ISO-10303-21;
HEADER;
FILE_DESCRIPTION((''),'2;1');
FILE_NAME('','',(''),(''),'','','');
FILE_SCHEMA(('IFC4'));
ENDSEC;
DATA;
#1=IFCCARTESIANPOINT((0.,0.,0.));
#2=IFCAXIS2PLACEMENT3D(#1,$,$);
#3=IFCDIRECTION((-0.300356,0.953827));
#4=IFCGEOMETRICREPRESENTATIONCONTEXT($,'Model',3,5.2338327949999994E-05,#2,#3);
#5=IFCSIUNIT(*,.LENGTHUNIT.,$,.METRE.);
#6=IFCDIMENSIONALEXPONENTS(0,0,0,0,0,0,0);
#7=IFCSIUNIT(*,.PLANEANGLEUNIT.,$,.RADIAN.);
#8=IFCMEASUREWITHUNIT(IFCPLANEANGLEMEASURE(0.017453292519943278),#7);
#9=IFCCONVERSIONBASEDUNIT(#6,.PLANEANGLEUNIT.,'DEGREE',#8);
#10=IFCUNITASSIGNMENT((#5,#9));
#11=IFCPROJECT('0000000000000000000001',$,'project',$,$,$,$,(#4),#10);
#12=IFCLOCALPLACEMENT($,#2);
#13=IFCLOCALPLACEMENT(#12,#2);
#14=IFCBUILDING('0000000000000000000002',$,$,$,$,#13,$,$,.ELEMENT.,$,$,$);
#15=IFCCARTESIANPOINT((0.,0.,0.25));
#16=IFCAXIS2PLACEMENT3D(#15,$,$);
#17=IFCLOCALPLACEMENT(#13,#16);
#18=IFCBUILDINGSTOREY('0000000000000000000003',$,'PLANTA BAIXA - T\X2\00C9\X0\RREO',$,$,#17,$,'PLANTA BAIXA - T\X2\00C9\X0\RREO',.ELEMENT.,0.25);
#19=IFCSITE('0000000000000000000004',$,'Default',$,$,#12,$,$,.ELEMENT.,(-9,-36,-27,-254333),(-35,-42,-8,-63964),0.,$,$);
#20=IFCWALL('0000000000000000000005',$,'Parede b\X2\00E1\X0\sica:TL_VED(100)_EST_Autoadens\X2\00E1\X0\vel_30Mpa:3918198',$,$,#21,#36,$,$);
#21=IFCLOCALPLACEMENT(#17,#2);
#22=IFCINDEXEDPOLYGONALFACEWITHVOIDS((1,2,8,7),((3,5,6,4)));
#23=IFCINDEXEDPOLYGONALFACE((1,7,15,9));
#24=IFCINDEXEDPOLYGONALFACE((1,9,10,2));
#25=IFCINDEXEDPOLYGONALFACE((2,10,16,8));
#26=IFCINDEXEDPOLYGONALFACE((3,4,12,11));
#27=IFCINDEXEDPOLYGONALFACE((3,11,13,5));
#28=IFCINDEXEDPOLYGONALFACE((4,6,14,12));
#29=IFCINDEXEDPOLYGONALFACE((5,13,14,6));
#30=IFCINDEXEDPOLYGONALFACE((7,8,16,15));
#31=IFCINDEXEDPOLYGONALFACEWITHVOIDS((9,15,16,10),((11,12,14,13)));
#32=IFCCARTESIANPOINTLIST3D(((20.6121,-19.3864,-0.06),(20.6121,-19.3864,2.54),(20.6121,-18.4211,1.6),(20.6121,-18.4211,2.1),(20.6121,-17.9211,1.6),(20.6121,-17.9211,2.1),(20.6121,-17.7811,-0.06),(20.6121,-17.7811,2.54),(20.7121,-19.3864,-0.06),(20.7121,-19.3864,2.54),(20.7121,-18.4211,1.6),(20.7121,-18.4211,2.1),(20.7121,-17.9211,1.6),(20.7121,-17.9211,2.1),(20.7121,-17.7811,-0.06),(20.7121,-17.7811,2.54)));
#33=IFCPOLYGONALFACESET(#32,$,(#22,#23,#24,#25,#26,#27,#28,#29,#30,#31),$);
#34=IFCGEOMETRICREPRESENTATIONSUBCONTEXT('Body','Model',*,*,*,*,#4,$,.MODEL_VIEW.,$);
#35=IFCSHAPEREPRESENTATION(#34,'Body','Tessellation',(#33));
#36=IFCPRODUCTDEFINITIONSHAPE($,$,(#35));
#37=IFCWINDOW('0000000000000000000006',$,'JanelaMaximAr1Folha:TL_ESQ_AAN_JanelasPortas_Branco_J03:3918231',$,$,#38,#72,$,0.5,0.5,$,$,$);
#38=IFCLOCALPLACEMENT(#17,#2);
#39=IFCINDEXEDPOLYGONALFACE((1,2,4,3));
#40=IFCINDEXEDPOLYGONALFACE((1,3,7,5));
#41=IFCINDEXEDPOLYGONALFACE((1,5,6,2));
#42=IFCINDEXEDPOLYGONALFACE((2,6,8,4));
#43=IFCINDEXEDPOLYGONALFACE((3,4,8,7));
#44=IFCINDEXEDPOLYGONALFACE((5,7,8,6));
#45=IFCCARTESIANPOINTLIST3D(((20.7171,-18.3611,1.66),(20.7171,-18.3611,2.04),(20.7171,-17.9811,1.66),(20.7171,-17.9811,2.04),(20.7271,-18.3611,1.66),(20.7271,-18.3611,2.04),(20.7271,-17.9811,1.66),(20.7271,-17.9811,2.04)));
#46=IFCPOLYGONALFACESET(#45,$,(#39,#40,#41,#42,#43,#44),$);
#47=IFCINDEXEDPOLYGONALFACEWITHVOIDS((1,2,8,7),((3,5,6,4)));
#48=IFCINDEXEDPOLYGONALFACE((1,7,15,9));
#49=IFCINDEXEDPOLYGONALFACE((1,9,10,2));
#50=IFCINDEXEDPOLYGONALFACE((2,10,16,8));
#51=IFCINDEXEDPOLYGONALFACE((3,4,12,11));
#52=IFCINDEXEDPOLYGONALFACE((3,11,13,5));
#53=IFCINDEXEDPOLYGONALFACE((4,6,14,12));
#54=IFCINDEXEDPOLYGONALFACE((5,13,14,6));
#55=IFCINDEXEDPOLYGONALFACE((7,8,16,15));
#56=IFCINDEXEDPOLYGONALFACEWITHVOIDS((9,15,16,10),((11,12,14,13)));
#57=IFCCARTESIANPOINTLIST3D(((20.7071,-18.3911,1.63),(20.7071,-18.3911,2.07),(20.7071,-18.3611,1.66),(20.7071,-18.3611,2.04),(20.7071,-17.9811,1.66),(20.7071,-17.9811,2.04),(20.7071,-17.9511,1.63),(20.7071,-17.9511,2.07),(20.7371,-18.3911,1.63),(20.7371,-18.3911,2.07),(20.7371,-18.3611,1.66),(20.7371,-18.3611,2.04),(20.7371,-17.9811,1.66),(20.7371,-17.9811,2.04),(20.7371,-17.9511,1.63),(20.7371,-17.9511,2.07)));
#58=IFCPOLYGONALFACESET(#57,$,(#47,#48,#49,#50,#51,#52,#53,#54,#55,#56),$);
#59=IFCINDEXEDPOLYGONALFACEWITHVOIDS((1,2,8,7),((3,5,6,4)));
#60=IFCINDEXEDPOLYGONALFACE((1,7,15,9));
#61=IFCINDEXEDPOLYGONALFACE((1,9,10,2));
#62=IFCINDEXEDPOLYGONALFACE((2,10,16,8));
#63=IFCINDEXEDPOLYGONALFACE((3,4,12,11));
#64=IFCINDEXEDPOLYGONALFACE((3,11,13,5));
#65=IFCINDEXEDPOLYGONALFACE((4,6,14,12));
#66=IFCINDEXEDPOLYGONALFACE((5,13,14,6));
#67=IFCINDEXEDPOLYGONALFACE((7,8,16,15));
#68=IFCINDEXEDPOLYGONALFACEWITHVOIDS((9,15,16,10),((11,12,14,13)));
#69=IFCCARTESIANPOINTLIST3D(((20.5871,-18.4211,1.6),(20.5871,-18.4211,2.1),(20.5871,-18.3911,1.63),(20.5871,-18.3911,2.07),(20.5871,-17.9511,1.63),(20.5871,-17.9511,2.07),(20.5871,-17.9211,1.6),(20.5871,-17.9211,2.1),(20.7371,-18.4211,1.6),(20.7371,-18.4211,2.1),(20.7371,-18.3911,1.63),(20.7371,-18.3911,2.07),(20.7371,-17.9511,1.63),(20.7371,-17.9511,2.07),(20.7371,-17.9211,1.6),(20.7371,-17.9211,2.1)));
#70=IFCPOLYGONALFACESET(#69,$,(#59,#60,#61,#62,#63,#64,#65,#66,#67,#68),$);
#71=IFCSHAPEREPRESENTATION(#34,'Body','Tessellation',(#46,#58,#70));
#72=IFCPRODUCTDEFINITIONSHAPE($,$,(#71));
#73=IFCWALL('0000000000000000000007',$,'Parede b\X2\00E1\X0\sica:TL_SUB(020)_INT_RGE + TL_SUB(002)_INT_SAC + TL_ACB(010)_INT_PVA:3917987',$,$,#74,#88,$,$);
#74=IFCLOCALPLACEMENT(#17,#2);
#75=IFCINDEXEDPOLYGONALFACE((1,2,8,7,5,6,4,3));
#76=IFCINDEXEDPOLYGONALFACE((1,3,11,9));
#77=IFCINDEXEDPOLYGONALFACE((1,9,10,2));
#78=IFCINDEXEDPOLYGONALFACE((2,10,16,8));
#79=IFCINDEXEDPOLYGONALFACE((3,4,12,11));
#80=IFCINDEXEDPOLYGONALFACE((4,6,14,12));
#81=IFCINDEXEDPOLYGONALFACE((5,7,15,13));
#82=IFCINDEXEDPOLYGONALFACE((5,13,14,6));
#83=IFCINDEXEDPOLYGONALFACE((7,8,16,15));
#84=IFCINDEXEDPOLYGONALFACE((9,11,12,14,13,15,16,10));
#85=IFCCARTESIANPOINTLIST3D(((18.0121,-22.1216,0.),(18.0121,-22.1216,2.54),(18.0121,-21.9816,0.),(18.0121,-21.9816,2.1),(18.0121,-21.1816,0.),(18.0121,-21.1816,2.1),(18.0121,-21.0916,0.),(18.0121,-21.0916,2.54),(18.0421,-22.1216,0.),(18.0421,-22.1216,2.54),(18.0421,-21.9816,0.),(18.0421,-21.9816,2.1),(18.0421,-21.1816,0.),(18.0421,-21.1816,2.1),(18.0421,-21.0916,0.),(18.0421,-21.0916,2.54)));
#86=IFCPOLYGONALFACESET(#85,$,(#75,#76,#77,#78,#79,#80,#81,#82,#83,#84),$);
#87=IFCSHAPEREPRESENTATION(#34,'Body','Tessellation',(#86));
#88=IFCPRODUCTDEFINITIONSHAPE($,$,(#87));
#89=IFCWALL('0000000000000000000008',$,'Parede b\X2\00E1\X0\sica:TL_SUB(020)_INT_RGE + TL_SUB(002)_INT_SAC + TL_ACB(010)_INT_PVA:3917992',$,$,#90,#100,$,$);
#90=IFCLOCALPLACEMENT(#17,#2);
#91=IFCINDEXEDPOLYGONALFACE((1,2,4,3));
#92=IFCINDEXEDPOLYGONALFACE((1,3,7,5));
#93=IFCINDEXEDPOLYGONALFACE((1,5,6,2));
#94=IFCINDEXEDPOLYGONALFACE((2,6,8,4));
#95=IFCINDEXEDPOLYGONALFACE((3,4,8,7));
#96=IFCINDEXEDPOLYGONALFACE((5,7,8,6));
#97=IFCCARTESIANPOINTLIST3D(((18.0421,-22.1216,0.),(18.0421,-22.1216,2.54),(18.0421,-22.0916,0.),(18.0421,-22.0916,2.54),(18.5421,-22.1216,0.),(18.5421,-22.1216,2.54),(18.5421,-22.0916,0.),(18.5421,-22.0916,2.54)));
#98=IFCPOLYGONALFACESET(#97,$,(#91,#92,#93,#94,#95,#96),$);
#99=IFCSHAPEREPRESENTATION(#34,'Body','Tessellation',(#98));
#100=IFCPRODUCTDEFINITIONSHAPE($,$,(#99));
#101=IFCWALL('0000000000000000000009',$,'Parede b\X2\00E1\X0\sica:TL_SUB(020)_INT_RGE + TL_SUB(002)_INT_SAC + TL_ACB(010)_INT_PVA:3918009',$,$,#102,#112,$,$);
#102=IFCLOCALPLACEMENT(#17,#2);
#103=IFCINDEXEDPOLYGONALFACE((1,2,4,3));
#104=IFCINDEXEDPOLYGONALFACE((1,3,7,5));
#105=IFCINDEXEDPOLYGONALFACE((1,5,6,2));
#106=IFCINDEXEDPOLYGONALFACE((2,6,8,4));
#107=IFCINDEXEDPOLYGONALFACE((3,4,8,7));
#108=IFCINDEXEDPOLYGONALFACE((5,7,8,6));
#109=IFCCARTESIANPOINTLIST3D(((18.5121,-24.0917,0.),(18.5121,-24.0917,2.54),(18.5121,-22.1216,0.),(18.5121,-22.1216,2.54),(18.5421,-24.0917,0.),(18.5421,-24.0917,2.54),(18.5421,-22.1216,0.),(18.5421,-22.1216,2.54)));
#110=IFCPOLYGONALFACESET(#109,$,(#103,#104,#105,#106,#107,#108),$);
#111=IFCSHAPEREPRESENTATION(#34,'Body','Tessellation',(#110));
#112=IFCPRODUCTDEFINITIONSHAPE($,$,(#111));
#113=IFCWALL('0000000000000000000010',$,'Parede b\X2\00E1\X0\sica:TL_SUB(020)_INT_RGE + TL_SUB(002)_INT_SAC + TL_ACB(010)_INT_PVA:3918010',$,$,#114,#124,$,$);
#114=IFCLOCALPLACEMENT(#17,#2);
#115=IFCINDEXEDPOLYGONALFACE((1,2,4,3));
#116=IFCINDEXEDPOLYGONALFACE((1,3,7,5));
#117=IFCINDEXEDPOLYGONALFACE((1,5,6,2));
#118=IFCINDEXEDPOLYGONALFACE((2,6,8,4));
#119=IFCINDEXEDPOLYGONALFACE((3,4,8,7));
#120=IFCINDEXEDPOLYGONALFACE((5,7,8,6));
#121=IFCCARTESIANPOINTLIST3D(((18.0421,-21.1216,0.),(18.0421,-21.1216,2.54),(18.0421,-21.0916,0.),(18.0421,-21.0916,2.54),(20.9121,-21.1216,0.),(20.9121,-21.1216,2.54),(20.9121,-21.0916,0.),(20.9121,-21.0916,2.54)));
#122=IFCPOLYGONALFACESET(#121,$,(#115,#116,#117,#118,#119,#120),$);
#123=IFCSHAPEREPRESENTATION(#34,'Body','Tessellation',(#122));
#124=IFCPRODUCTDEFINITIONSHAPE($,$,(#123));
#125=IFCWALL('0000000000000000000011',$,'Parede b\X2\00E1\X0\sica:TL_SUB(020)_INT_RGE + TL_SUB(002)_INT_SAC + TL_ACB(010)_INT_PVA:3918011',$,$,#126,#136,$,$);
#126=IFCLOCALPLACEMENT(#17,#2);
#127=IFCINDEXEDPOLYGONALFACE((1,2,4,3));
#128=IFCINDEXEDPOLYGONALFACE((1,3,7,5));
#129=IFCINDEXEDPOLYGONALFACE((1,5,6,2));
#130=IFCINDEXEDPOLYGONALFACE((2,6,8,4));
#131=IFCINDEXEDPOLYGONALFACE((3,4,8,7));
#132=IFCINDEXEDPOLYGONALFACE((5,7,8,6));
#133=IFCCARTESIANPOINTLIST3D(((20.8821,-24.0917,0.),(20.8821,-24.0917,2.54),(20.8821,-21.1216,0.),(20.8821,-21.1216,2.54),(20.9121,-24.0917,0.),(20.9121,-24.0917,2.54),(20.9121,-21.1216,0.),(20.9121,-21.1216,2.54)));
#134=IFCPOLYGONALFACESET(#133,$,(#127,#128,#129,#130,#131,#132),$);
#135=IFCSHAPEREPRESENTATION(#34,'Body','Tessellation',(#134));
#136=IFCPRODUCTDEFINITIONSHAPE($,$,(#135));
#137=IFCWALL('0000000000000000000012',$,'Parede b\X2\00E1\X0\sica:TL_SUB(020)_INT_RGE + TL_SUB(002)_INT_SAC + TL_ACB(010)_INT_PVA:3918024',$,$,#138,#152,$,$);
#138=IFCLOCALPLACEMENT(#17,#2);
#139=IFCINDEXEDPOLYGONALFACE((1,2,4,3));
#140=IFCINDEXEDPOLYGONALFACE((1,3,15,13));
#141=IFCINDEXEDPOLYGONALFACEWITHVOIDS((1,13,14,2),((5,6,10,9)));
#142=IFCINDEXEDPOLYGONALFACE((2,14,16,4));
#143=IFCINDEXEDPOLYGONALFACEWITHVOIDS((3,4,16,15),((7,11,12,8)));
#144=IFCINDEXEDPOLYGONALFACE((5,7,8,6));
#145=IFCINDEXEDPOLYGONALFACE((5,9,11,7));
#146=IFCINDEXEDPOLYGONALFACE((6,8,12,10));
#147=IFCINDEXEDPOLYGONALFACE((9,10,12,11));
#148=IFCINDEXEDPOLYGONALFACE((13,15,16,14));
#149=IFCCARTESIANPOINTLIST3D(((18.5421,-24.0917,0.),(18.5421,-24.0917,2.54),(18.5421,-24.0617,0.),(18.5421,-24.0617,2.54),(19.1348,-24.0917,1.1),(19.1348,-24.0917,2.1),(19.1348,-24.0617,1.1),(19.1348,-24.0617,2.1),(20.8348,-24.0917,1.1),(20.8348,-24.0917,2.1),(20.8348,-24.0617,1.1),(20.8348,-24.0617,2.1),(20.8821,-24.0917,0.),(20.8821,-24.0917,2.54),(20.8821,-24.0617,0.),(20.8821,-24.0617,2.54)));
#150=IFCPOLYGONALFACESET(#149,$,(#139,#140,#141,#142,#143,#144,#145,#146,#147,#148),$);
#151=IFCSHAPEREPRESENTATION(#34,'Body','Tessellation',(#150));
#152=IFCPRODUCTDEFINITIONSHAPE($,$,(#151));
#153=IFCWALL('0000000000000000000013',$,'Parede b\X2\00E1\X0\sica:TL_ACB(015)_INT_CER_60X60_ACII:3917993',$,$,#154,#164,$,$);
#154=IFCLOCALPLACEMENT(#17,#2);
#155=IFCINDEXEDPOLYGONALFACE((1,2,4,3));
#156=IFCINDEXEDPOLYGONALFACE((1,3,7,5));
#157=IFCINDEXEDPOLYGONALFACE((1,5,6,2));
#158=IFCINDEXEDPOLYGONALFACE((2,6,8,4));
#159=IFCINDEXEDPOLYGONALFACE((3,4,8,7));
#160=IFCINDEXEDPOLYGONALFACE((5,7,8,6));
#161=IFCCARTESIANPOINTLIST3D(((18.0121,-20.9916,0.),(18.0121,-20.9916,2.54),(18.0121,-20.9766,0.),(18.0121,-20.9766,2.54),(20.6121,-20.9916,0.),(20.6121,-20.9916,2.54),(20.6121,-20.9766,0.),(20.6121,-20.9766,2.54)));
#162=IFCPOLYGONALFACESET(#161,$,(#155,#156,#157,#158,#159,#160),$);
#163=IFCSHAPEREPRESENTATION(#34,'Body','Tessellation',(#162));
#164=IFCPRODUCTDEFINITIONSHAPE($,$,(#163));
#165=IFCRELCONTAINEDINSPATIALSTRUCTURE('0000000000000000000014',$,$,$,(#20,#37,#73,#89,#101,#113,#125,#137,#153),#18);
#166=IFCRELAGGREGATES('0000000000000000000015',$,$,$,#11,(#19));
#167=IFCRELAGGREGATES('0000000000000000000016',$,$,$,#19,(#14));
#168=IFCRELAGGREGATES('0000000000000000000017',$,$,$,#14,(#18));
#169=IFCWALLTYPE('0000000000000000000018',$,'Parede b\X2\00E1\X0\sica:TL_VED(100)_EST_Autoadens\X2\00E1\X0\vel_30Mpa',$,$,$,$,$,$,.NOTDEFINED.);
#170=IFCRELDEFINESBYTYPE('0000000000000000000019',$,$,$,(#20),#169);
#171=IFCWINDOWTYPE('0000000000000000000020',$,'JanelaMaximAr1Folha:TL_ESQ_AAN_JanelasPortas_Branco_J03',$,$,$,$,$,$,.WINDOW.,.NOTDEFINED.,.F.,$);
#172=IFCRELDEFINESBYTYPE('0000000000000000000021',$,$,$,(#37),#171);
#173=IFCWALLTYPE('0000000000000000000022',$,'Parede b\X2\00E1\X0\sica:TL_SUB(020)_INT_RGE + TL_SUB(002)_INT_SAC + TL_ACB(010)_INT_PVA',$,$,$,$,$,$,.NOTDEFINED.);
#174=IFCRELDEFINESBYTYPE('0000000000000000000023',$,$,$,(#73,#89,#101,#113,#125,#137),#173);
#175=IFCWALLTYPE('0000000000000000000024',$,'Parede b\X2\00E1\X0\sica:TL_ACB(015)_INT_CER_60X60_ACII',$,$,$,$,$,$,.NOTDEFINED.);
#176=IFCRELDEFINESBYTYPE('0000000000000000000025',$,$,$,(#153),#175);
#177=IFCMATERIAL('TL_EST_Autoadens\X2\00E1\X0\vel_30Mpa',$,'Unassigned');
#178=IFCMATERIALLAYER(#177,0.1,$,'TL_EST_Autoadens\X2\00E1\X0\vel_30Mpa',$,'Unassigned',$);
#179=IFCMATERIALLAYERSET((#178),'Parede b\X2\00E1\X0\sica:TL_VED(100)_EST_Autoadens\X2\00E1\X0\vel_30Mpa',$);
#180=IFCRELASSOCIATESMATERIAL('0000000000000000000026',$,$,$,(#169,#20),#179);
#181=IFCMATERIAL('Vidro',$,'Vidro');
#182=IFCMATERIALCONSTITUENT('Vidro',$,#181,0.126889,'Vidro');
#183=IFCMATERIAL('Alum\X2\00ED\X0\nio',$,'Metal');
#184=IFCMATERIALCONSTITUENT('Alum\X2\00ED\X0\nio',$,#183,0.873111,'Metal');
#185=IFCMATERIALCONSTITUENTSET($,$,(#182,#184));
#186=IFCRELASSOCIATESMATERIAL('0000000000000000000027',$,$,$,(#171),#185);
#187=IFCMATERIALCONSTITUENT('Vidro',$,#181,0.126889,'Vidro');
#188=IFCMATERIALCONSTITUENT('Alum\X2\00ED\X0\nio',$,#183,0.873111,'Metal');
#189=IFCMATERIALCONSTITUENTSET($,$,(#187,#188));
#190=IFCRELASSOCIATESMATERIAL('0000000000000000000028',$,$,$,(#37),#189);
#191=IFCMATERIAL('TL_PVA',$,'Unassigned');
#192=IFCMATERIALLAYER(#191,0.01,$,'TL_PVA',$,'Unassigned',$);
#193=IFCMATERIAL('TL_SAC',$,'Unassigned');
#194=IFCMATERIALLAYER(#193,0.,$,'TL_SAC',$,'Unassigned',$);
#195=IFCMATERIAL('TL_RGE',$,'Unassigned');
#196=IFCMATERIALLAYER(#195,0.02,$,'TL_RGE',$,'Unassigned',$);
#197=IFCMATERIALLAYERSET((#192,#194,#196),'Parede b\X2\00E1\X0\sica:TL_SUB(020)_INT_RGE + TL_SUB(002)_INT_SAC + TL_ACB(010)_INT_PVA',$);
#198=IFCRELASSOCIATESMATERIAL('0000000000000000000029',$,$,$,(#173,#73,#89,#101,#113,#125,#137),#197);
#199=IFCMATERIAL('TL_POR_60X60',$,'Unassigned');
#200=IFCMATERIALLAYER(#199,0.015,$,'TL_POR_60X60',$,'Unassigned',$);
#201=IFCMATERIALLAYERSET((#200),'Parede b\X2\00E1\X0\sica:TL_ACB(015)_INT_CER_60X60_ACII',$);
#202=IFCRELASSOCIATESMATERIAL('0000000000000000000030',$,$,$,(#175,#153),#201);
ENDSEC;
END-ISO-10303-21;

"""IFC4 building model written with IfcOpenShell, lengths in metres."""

from ifc_helpers import new_model, entity, si_unit, converted_unit, direction, frame, frame_2d, origin, place, context, subcontext, project, spatial, polyline, rectangle, outline, extrude, source, transform, mapped, material, layer, layer_set, layer_usage, constituent, constituent_set, type_object, type_shapes, element, fill, save


model = new_model("IFC4")

# Units and contexts
model_context = context("Model", 3, precision=5.2338327949999994e-05, world=origin(), true_north=direction((-0.300356, 0.953827)))
body_context = subcontext(model_context, "Body", "Model", "MODEL_VIEW")
ifc_project = project(units=[si_unit("LENGTHUNIT", "METRE"), converted_unit("PLANEANGLEUNIT", "DEGREE", entity("IfcPlaneAngleMeasure", 0.017453292519943278), si_unit("PLANEANGLEUNIT", "RADIAN"), dimensions=[0, 0, 0, 0, 0, 0, 0])], contexts=[model_context])

# Site, building, storey
site_placement = place(None, origin())
site = spatial("IfcSite", under=ifc_project, at=site_placement, Name="Default", CompositionType="ELEMENT", RefLatitude=(-9, -36, -27, -254333), RefLongitude=(-35, -42, -8, -63964), RefElevation=0.0)
building_placement = place(site_placement, origin())
building = spatial("IfcBuilding", under=site, at=building_placement, CompositionType="ELEMENT")
storey_placement = place(building_placement, frame((0.0, 0.0, 0.25)))
storey = spatial("IfcBuildingStorey", under=building, at=storey_placement, Name="PLANTA BAIXA - TÉRREO", LongName="PLANTA BAIXA - TÉRREO", CompositionType="ELEMENT", Elevation=0.25)

# Shared definitions
ifc_material_1 = material(Name="TL_EST_Autoadensável_30Mpa", Category="Unassigned")
ifc_layer_1 = layer(ifc_material_1, 0.1, Name="TL_EST_Autoadensável_30Mpa", Category="Unassigned")
ifc_layer_set_1 = layer_set([ifc_layer_1], Name="Parede básica:TL_VED(100)_EST_Autoadensável_30Mpa")
wall_type_1 = type_object("IfcWallType", Name="Parede básica:TL_VED(100)_EST_Autoadensável_30Mpa", PredefinedType="NOTDEFINED", material=ifc_layer_set_1)

# Wall, opening, window
ifc_material_2 = material(Name="Vidro", Category="Vidro")
ifc_material_3 = material(Name="Alumínio", Category="Metal")
ifc_layer_usage_1 = layer_usage(ifc_layer_set_1, "AXIS2", "POSITIVE", -0.05)
wall_1_placement = place(storey_placement, frame((20.6621, -19.3864, -0.06), z_axis=(0.0, 0.0, 1.0), x_axis=(0.0, 1.0, 0.0)))
wall_1 = element("IfcWall", 1, at=wall_1_placement, inside=storey, type_object=wall_type_1, material=ifc_layer_usage_1, Name="Parede básica:TL_VED(100)_EST_Autoadensável_30Mpa:3918198", context=body_context, shape_type="SweptSolid", body=[
    extrude(rectangle(XDim=1.6052, YDim=0.1, at=frame_2d((0.8026, 0.0), x_axis=(-1.0, 0.0))), origin(), (0.0, 0.0, 1.0), 2.6),
])
opening_1_placement = place(wall_1_placement, frame((0.9652, -0.05, 1.66)))
opening_1 = element("IfcOpeningElement", 2, at=opening_1_placement, cuts=wall_1, PredefinedType="OPENING", context=body_context, shape_type="SweptSolid", body=[
    extrude(rectangle(XDim=0.5, YDim=0.5, at=frame_2d((0.25, 0.25), x_axis=(1.0, 0.0))), frame((0.0, 0.0, 0.0), z_axis=(0.0, 1.0, 0.0), x_axis=(0.0, 0.0, 1.0)), (0.0, 0.0, 1.0), 0.1),
])
ifc_constituent_1 = constituent(ifc_material_2, Name="Vidro", Category="Vidro", fraction=0.126889)
ifc_constituent_2 = constituent(ifc_material_3, Name="Alumínio", Category="Metal", fraction=0.873111)
ifc_constituent_set_1 = constituent_set(constituents=[ifc_constituent_1, ifc_constituent_2])
ifc_constituent_3 = constituent(ifc_material_2, Name="Vidro", Category="Vidro", fraction=0.126889)
ifc_constituent_4 = constituent(ifc_material_3, Name="Alumínio", Category="Metal", fraction=0.873111)
ifc_constituent_set_2 = constituent_set(constituents=[ifc_constituent_3, ifc_constituent_4])
window_type_1 = type_object("IfcWindowType", Name="JanelaMaximAr1Folha:TL_ESQ_AAN_JanelasPortas_Branco_J03", ParameterTakesPrecedence=False, PartitioningType="NOTDEFINED", PredefinedType="WINDOW", material=ifc_constituent_set_2)
shared_shape_1 = source(origin(), body_context, "Body", "SweptSolid", [
    extrude(rectangle(XDim=0.38, YDim=0.01, at=frame_2d((0.0, 0.0), x_axis=(1.0, 0.0))), frame((0.25, -0.01, 0.06)), (0.0, 0.0, 1.0), 0.38),
    extrude(outline(polyline([(-0.22, -0.22), (0.22, -0.22), (0.22, 0.22), (-0.22, 0.22), (-0.22, -0.22)]), holes=[polyline([(0.19, 0.19), (0.19, -0.19), (-0.19, -0.19), (-0.19, 0.19), (0.19, 0.19)])]), frame((0.25, 0.005, 0.25), z_axis=(0.0, -1.0, 0.0), x_axis=(0.0, 0.0, -1.0)), (0.0, 0.0, 1.0), 0.03),
    extrude(outline(polyline([(-0.25, -0.25), (0.25, -0.25), (0.25, 0.25), (-0.25, 0.25), (-0.25, -0.25)]), holes=[polyline([(-0.22, -0.22), (-0.22, 0.22), (0.22, 0.22), (0.22, -0.22), (-0.22, -0.22)])]), frame((0.25, 0.125, 0.25), z_axis=(0.0, -1.0, 0.0), x_axis=(0.0, 0.0, -1.0)), (0.0, 0.0, 1.0), 0.15),
])
type_shapes(window_type_1, [shared_shape_1])
window_1_placement = place(opening_1_placement, origin())
window_1 = element("IfcWindow", 3, at=window_1_placement, inside=storey, type_object=window_type_1, material=ifc_constituent_set_1, Name="JanelaMaximAr1Folha:TL_ESQ_AAN_JanelasPortas_Branco_J03:3918231", OverallHeight=0.5, OverallWidth=0.5, context=body_context, shape_type="MappedRepresentation", body=[
    mapped(shared_shape_1, transform((0.0, 0.0, 0.0), scale=1.0)),
])
fill(opening_1, window_1)

# Wall, opening
ifc_material_4 = material(Name="TL_PVA", Category="Unassigned")
ifc_layer_2 = layer(ifc_material_4, 0.01, Name="TL_PVA", Category="Unassigned")
ifc_material_5 = material(Name="TL_SAC", Category="Unassigned")
ifc_layer_3 = layer(ifc_material_5, 0.0, Name="TL_SAC", Category="Unassigned")
ifc_material_6 = material(Name="TL_RGE", Category="Unassigned")
ifc_layer_4 = layer(ifc_material_6, 0.02, Name="TL_RGE", Category="Unassigned")
ifc_layer_set_2 = layer_set([ifc_layer_2, ifc_layer_3, ifc_layer_4], Name="Parede básica:TL_SUB(020)_INT_RGE + TL_SUB(002)_INT_SAC + TL_ACB(010)_INT_PVA")
ifc_layer_usage_2 = layer_usage(ifc_layer_set_2, "AXIS2", "POSITIVE", -0.015)
wall_type_2 = type_object("IfcWallType", Name="Parede básica:TL_SUB(020)_INT_RGE + TL_SUB(002)_INT_SAC + TL_ACB(010)_INT_PVA", PredefinedType="NOTDEFINED", material=ifc_layer_set_2)
wall_2_placement = place(storey_placement, frame((18.0271, -22.1216, 0.0), z_axis=(0.0, 0.0, 1.0), x_axis=(0.0, 1.0, 0.0)))
wall_2 = element("IfcWall", 4, at=wall_2_placement, inside=storey, type_object=wall_type_2, material=ifc_layer_usage_2, Name="Parede básica:TL_SUB(020)_INT_RGE + TL_SUB(002)_INT_SAC + TL_ACB(010)_INT_PVA:3917987", context=body_context, shape_type="SweptSolid", body=[
    extrude(rectangle(XDim=1.03, YDim=0.03, at=frame_2d((0.515, 0.0), x_axis=(-1.0, 0.0))), origin(), (0.0, 0.0, 1.0), 2.54),
])
opening_2_placement = place(wall_2_placement, frame((22.1216, 18.0271, 0.0)))
element("IfcOpeningElement", 5, at=opening_2_placement, cuts=wall_2, PredefinedType="OPENING", context=body_context, shape_type="SweptSolid", body=[
    extrude(rectangle(XDim=2.1, YDim=0.8, at=frame_2d((0.0, 0.0), x_axis=(0.0, 1.0))), frame((-21.5816, -19.4361, 1.05), z_axis=(0.0, 1.0, 0.0), x_axis=(-1.0, 0.0, 0.0)), (0.0, 0.0, 1.0), 3.048),
])

# Walls
ifc_layer_usage_3 = layer_usage(ifc_layer_set_2, "AXIS2", "POSITIVE", -0.015)
wall_3_placement = place(storey_placement, frame((18.5421, -22.1066, 0.0), z_axis=(0.0, 0.0, 1.0), x_axis=(-1.0, 0.0, 0.0)))
element("IfcWall", 6, at=wall_3_placement, inside=storey, type_object=wall_type_2, material=ifc_layer_usage_3, Name="Parede básica:TL_SUB(020)_INT_RGE + TL_SUB(002)_INT_SAC + TL_ACB(010)_INT_PVA:3917992", context=body_context, shape_type="SweptSolid", body=[
    extrude(rectangle(XDim=0.5, YDim=0.03, at=frame_2d((0.25, 0.0), x_axis=(-1.0, 0.0))), origin(), (0.0, 0.0, 1.0), 2.54),
])
ifc_layer_usage_4 = layer_usage(ifc_layer_set_2, "AXIS2", "NEGATIVE", 0.015)
wall_4_placement = place(storey_placement, frame((18.5271, -22.1216, 0.0), z_axis=(0.0, 0.0, 1.0), x_axis=(0.0, -1.0, 0.0)))
element("IfcWall", 7, at=wall_4_placement, inside=storey, type_object=wall_type_2, material=ifc_layer_usage_4, Name="Parede básica:TL_SUB(020)_INT_RGE + TL_SUB(002)_INT_SAC + TL_ACB(010)_INT_PVA:3918009", context=body_context, shape_type="SweptSolid", body=[
    extrude(rectangle(XDim=1.9701, YDim=0.03, at=frame_2d((0.9851, 0.0), x_axis=(-1.0, 0.0))), origin(), (0.0, 0.0, 1.0), 2.54),
])
ifc_layer_usage_5 = layer_usage(ifc_layer_set_2, "AXIS2", "NEGATIVE", 0.015)
wall_5_placement = place(storey_placement, frame((20.9121, -21.1066, 0.0), z_axis=(0.0, 0.0, 1.0), x_axis=(-1.0, 0.0, 0.0)))
element("IfcWall", 8, at=wall_5_placement, inside=storey, type_object=wall_type_2, material=ifc_layer_usage_5, Name="Parede básica:TL_SUB(020)_INT_RGE + TL_SUB(002)_INT_SAC + TL_ACB(010)_INT_PVA:3918010", context=body_context, shape_type="SweptSolid", body=[
    extrude(rectangle(XDim=2.87, YDim=0.03, at=frame_2d((1.435, 0.0), x_axis=(-1.0, 0.0))), origin(), (0.0, 0.0, 1.0), 2.54),
])
ifc_layer_usage_6 = layer_usage(ifc_layer_set_2, "AXIS2", "NEGATIVE", 0.015)
wall_6_placement = place(storey_placement, frame((20.8971, -24.0917, 0.0), z_axis=(0.0, 0.0, 1.0), x_axis=(0.0, 1.0, 0.0)))
element("IfcWall", 9, at=wall_6_placement, inside=storey, type_object=wall_type_2, material=ifc_layer_usage_6, Name="Parede básica:TL_SUB(020)_INT_RGE + TL_SUB(002)_INT_SAC + TL_ACB(010)_INT_PVA:3918011", context=body_context, shape_type="SweptSolid", body=[
    extrude(rectangle(XDim=2.9701, YDim=0.03, at=frame_2d((1.4851, 0.0), x_axis=(-1.0, 0.0))), origin(), (0.0, 0.0, 1.0), 2.54),
])

# Wall, opening
ifc_layer_usage_7 = layer_usage(ifc_layer_set_2, "AXIS2", "NEGATIVE", 0.015)
wall_7_placement = place(storey_placement, frame((18.5421, -24.0767, 0.0)))
wall_7 = element("IfcWall", 10, at=wall_7_placement, inside=storey, type_object=wall_type_2, material=ifc_layer_usage_7, Name="Parede básica:TL_SUB(020)_INT_RGE + TL_SUB(002)_INT_SAC + TL_ACB(010)_INT_PVA:3918024", context=body_context, shape_type="SweptSolid", body=[
    extrude(rectangle(XDim=2.34, YDim=0.03, at=frame_2d((1.17, 0.0), x_axis=(-1.0, 0.0))), origin(), (0.0, 0.0, 1.0), 2.54),
])
opening_3_placement = place(wall_7_placement, frame((-18.5421, 24.0767, 1.1)))
element("IfcOpeningElement", 11, at=opening_3_placement, cuts=wall_7, PredefinedType="OPENING", context=body_context, shape_type="SweptSolid", body=[
    extrude(rectangle(XDim=1.0, YDim=1.7, at=frame_2d((0.0, 0.0), x_axis=(0.0, 1.0))), frame((19.9848, -25.6157, 0.5), z_axis=(0.0, 1.0, 0.0), x_axis=(1.0, 0.0, 0.0)), (0.0, 0.0, 1.0), 3.048),
])

# Wall
ifc_material_7 = material(Name="TL_POR_60X60", Category="Unassigned")
ifc_layer_5 = layer(ifc_material_7, 0.015, Name="TL_POR_60X60", Category="Unassigned")
ifc_layer_set_3 = layer_set([ifc_layer_5], Name="Parede básica:TL_ACB(015)_INT_CER_60X60_ACII")
ifc_layer_usage_8 = layer_usage(ifc_layer_set_3, "AXIS2", "POSITIVE", -0.0075)
wall_type_3 = type_object("IfcWallType", Name="Parede básica:TL_ACB(015)_INT_CER_60X60_ACII", PredefinedType="NOTDEFINED", material=ifc_layer_set_3)
wall_8_placement = place(storey_placement, frame((20.6121, -20.9841, 0.0), z_axis=(0.0, 0.0, 1.0), x_axis=(-1.0, 0.0, 0.0)))
element("IfcWall", 12, at=wall_8_placement, inside=storey, type_object=wall_type_3, material=ifc_layer_usage_8, Name="Parede básica:TL_ACB(015)_INT_CER_60X60_ACII:3917993", context=body_context, shape_type="SweptSolid", body=[
    extrude(rectangle(XDim=2.6, YDim=0.015, at=frame_2d((1.3, 0.0), x_axis=(-1.0, 0.0))), origin(), (0.0, 0.0, 1.0), 2.54),
])

save(model, "model.ifc")
